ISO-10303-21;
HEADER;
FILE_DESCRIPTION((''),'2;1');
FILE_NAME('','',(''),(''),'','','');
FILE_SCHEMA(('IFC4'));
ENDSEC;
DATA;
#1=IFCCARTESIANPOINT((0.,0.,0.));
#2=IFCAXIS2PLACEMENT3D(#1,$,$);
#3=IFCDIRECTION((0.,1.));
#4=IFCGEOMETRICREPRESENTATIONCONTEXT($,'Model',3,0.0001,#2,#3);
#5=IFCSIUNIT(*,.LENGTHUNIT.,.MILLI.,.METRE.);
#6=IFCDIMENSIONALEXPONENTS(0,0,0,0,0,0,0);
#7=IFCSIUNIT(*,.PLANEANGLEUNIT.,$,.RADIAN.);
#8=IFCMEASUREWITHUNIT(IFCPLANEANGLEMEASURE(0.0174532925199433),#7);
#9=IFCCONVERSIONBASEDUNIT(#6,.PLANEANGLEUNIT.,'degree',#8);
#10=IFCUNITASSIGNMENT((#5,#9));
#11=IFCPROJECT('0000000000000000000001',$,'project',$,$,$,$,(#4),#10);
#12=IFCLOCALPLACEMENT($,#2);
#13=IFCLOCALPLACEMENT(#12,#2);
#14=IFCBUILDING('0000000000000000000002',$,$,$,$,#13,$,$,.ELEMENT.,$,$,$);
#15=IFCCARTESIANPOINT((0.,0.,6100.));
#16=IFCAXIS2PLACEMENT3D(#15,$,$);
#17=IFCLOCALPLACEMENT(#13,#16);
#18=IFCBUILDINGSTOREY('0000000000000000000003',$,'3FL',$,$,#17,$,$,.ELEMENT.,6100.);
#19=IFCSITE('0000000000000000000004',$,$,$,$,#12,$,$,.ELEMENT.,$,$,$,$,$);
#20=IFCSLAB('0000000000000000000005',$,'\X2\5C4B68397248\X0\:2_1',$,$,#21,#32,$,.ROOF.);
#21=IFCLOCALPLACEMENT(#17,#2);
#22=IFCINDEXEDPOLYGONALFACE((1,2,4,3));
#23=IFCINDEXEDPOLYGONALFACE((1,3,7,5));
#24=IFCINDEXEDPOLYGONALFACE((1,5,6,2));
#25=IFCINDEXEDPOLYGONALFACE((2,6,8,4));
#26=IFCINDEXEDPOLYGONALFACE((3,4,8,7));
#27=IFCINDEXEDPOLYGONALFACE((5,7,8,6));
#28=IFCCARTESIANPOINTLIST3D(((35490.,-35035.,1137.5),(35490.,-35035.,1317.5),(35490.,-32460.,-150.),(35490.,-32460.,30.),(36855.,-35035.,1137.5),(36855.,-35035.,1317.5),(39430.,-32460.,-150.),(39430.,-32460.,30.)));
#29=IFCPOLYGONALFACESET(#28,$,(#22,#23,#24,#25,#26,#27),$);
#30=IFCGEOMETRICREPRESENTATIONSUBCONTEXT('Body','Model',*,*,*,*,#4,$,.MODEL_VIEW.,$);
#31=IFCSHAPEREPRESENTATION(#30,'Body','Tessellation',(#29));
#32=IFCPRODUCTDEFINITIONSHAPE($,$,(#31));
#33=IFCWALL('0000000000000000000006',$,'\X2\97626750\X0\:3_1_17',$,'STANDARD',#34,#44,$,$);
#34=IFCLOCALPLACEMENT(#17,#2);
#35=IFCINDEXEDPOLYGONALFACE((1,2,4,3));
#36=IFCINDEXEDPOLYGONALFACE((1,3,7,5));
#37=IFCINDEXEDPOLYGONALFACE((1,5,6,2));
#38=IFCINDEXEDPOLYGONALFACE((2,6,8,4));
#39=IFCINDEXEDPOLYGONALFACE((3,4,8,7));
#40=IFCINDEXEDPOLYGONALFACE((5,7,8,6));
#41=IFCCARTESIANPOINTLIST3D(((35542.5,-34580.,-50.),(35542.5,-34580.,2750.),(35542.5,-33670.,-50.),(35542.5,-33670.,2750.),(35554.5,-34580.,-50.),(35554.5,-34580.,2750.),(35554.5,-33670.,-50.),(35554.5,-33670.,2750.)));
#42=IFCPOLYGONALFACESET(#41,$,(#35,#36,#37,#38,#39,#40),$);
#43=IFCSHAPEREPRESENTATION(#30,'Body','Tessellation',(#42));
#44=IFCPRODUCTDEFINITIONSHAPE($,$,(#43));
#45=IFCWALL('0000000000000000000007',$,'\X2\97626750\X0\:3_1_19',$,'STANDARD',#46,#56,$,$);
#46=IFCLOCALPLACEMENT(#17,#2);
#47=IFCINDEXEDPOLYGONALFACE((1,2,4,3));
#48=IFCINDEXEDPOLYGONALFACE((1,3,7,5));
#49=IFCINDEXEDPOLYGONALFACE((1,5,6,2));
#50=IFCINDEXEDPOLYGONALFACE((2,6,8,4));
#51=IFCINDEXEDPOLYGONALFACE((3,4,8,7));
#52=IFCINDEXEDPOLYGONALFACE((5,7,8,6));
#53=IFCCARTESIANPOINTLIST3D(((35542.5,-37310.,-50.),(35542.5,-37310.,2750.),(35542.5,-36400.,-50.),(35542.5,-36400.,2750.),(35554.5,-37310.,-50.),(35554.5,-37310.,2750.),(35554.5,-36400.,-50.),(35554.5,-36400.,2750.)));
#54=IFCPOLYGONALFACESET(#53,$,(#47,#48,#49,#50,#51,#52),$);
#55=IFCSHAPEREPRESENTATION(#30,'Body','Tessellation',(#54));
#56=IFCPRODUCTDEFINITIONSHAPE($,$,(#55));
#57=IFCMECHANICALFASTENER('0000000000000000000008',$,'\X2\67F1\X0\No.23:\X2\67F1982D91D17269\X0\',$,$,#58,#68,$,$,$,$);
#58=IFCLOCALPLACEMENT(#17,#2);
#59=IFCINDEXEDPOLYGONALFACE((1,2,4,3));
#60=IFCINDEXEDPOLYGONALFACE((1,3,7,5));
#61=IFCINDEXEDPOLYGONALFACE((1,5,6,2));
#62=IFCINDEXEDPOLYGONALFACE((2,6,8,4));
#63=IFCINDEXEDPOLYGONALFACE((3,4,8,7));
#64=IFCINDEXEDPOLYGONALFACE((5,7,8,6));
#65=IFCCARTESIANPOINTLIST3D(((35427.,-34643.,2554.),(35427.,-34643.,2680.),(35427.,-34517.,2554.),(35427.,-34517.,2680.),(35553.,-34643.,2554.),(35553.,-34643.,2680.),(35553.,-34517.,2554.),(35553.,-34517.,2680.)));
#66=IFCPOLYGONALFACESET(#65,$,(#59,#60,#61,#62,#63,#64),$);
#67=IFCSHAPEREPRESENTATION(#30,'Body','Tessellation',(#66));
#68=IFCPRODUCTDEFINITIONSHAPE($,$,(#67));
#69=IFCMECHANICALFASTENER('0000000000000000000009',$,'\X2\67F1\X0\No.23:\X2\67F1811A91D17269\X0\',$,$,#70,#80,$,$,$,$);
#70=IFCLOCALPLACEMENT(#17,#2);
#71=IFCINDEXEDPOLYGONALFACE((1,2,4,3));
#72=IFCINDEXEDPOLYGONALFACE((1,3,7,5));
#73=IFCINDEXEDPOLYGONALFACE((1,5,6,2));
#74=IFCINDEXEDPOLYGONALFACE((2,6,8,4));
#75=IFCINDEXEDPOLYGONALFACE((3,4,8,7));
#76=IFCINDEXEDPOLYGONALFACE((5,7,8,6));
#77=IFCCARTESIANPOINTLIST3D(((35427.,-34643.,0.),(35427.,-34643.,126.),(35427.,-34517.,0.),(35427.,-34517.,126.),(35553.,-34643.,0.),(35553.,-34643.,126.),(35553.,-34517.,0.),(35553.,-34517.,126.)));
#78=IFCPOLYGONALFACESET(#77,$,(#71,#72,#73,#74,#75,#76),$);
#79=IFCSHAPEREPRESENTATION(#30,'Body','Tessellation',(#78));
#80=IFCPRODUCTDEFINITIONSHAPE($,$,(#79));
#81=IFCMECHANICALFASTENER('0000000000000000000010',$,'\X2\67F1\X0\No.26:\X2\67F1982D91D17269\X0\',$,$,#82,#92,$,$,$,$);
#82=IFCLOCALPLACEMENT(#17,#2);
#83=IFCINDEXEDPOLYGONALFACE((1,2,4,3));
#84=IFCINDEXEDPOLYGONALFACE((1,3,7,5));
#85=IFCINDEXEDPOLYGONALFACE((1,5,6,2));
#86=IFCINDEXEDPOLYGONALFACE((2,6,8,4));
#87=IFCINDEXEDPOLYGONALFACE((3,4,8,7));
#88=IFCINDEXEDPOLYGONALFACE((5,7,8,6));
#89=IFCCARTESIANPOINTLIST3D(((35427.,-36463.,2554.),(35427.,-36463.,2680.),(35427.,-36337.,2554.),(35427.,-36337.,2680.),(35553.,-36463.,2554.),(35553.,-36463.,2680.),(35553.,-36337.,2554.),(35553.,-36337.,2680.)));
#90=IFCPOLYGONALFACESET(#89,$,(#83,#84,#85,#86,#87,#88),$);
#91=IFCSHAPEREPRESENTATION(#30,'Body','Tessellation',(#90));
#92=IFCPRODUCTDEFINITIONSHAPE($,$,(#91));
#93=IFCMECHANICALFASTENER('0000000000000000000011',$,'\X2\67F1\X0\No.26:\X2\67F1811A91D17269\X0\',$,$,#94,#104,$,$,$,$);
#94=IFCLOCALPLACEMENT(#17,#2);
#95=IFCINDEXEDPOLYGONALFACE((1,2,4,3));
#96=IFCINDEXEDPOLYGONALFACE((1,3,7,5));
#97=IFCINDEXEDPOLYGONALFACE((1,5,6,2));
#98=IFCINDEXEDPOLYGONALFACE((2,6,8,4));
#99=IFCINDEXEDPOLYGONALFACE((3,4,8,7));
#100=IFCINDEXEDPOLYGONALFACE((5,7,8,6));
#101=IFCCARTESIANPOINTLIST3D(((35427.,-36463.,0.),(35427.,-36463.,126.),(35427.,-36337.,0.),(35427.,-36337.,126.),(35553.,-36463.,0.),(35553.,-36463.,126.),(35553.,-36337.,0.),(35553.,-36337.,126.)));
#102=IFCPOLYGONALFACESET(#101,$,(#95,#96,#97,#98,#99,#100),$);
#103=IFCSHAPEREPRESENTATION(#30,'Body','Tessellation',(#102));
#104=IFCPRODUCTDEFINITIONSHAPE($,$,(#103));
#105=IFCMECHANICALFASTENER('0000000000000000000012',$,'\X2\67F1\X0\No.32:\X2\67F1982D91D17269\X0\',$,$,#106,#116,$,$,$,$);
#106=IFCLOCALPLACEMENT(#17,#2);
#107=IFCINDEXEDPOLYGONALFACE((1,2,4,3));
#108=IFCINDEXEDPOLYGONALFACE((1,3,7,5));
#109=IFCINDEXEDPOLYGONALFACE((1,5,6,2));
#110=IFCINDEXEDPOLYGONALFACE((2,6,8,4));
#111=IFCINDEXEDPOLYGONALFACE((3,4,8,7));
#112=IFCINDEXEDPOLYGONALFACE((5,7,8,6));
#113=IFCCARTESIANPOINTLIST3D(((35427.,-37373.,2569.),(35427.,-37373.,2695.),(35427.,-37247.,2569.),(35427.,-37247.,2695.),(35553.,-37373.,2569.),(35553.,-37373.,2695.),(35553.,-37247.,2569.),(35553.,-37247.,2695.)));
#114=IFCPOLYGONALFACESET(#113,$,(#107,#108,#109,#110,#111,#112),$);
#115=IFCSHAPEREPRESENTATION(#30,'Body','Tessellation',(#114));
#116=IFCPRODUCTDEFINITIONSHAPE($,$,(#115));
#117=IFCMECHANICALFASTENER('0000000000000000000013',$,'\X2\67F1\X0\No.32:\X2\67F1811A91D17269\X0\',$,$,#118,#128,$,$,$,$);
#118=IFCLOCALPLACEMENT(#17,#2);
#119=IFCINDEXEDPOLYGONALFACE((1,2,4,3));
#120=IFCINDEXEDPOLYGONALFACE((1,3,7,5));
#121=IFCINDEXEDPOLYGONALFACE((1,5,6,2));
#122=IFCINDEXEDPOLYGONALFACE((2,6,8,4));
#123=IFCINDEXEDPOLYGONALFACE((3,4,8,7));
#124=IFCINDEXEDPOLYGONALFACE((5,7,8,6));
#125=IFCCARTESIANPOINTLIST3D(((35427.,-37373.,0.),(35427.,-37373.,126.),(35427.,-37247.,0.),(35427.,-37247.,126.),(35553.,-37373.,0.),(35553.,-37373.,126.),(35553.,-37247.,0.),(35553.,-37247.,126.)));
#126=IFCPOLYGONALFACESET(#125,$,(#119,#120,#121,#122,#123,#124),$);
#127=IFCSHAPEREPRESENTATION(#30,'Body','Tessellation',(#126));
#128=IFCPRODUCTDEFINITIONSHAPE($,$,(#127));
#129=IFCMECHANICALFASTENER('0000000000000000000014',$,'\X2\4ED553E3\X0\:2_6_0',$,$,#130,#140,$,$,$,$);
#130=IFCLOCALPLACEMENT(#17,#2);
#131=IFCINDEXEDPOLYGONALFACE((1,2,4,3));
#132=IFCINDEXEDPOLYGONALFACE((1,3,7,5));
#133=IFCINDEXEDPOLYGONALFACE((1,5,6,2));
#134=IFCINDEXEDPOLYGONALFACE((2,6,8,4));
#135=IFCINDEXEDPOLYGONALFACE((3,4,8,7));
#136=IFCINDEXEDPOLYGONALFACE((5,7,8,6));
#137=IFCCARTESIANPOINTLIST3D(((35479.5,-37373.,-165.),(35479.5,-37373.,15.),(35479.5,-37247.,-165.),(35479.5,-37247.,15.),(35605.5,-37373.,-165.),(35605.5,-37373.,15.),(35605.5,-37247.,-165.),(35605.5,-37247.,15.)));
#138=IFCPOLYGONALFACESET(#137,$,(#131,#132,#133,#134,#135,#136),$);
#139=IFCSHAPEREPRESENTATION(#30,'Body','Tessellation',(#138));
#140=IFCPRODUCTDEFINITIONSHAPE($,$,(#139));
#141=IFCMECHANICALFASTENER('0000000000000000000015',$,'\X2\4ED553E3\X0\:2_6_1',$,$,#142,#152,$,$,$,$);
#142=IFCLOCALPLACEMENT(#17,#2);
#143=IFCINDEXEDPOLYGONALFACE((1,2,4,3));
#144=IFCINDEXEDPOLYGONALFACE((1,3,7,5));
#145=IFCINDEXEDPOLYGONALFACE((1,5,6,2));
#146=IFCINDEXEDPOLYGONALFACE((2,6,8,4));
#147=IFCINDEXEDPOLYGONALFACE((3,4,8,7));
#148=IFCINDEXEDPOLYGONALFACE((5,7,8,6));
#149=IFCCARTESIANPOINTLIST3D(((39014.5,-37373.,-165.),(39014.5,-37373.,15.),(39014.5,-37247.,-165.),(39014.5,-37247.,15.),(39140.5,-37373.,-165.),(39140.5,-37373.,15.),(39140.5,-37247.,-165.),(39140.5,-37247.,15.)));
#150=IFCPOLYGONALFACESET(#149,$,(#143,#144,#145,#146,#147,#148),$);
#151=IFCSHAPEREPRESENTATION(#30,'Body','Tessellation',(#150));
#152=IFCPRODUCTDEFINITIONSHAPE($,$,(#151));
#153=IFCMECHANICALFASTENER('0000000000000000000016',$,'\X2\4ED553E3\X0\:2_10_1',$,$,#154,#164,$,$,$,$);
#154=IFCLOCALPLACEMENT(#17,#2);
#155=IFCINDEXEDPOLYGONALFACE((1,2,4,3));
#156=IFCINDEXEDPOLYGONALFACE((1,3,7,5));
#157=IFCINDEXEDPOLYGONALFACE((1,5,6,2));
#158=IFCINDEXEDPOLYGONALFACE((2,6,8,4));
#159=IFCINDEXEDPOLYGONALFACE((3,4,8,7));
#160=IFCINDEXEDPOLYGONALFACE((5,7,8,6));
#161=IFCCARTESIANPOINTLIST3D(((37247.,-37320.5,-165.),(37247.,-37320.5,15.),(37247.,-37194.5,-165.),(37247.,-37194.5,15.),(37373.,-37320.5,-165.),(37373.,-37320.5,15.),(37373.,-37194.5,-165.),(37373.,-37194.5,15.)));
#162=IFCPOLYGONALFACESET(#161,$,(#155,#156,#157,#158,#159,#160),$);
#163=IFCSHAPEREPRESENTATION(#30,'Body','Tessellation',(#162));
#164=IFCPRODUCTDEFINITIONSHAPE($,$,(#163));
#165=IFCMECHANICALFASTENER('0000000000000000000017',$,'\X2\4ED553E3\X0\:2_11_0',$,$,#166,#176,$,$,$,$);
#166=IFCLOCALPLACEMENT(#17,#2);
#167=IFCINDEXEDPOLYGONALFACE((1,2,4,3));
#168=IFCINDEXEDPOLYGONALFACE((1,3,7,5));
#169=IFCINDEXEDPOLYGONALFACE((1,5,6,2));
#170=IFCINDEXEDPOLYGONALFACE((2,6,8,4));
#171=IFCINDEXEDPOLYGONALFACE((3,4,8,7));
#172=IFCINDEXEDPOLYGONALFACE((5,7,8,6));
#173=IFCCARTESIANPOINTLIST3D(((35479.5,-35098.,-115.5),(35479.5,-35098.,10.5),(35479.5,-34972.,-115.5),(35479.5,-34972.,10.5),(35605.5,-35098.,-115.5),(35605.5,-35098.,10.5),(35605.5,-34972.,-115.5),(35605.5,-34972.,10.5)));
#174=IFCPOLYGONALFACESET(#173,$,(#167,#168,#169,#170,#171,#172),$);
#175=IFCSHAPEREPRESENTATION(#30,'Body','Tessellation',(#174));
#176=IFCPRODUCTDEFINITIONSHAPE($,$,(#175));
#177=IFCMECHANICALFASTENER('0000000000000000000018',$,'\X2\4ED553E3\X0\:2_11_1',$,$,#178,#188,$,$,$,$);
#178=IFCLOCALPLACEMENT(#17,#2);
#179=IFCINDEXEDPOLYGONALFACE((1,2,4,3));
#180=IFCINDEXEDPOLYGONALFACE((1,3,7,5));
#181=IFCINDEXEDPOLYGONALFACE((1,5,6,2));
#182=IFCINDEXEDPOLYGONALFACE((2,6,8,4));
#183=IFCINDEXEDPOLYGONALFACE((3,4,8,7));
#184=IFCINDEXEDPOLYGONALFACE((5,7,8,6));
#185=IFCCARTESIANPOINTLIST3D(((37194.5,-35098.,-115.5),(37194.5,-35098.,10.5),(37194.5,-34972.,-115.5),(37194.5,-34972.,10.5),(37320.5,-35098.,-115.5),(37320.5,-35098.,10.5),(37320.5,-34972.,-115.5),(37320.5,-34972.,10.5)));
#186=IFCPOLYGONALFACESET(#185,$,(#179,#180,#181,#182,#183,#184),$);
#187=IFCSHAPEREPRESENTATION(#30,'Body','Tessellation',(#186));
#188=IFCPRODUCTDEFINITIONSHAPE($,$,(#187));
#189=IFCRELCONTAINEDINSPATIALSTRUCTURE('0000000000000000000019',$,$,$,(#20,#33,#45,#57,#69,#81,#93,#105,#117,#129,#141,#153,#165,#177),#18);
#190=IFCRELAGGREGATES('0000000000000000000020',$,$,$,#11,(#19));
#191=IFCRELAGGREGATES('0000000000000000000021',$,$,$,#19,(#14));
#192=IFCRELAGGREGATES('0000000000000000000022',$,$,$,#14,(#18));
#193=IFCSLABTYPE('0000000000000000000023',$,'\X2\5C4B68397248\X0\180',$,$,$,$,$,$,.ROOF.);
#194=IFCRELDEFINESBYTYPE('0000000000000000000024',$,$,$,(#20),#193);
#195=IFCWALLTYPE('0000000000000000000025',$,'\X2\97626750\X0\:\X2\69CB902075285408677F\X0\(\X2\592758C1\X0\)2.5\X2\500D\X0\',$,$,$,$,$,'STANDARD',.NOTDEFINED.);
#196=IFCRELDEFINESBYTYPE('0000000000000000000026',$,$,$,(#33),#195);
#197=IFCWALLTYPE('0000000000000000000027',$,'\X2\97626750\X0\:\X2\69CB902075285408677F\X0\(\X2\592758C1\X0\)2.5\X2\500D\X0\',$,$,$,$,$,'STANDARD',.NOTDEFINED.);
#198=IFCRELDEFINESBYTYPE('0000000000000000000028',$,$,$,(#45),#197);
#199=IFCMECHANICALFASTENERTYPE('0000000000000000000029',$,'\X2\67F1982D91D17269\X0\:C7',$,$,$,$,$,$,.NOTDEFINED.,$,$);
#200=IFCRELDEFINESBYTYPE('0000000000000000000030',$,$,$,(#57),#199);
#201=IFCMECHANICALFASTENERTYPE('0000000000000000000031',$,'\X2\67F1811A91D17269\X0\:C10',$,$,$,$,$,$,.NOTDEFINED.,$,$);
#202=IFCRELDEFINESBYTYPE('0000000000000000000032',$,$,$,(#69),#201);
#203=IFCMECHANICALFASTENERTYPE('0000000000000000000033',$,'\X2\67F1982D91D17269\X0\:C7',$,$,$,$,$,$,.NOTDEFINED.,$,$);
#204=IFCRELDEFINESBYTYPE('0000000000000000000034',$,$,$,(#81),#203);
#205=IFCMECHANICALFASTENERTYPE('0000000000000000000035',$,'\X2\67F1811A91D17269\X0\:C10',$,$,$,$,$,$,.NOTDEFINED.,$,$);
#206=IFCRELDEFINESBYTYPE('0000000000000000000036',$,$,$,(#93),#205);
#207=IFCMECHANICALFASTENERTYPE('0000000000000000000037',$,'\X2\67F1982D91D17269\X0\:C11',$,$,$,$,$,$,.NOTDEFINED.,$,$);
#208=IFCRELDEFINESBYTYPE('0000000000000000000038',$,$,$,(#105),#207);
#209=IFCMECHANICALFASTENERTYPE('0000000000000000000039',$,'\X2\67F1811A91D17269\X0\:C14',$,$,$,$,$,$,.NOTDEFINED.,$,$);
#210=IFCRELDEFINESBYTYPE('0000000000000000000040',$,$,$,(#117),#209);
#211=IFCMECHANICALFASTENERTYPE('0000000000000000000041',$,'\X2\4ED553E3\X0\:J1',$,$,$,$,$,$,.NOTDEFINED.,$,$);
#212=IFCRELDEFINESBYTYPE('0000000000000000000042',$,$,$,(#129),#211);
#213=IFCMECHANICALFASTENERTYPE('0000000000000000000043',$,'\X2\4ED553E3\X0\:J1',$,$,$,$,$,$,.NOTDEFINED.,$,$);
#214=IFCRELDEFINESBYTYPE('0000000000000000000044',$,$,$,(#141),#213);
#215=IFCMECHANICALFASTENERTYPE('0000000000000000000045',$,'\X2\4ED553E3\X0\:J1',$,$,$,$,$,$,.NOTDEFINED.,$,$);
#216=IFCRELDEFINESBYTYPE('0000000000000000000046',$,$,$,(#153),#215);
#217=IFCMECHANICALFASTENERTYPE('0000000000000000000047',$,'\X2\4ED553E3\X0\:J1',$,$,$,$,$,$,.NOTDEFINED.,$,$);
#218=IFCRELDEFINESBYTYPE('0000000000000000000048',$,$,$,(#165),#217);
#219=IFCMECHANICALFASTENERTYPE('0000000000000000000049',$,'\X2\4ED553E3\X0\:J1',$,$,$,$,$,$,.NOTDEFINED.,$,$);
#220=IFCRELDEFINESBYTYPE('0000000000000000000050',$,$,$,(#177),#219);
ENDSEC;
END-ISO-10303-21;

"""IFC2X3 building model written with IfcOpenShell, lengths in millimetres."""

from ifc_helpers import new_model, entity, si_unit, converted_unit, direction, frame, origin, origin_with_axes, origin_2d, place, context, subcontext, project, spatial, polyline, rectangle, outline, extrude, type_object, element, save


model = new_model("IFC2X3")

# Units and contexts
model_context = context("Model", 3, precision=0.0001, world=origin(), true_north=direction((0.0, 1.0)))
body_context = subcontext(model_context, "Body", "Model", "MODEL_VIEW")
ifc_project = project(units=[si_unit("LENGTHUNIT", "METRE", prefix="MILLI"), converted_unit("PLANEANGLEUNIT", "degree", entity("IfcPlaneAngleMeasure", 0.0174532925199433), si_unit("PLANEANGLEUNIT", "RADIAN"), dimensions=[0, 0, 0, 0, 0, 0, 0])], contexts=[model_context])

# Site, building, storey
site_placement = place(None, origin())
site = spatial("IfcSite", under=ifc_project, at=site_placement, CompositionType="ELEMENT")
building_placement = place(site_placement, origin())
building = spatial("IfcBuilding", under=site, at=building_placement, CompositionType="ELEMENT")
storey_placement = place(building_placement, frame((0.0, 0.0, 6100.0)))
storey = spatial("IfcBuildingStorey", under=building, at=storey_placement, Name="3FL", CompositionType="ELEMENT", Elevation=6100.0)

# Slab
slab_type = type_object("IfcSlabType", Name="屋根版180", PredefinedType="ROOF")
slab_placement = place(storey_placement, frame((35490.0, -35035.0, 1137.5), z_axis=(0.0, 0.447214, 0.894427), x_axis=(1.0, 0.0, 0.0)))
element("IfcSlab", 1, at=slab_placement, inside=storey, type_object=slab_type, Name="屋根版:2_1", PredefinedType="ROOF", context=body_context, shape_type="SweptSolid", body=[
    extrude(outline(polyline([(0.0, 0.0, 0.0), (1365.0, 0.0, 0.0), (3940.0, 2878.9, 0.0), (0.0, 2878.9, 0.0), (0.0, 0.0, 0.0)])), origin_with_axes(), (0.0, -0.447214, 0.894427), 180.0),
])

# Walls
wall_type_1 = type_object("IfcWallType", Name="面材:構造用合板(大壁)2.5倍", ElementType="STANDARD", PredefinedType="NOTDEFINED")
wall_1_placement = place(storey_placement, frame((35554.5, -34125.0, -50.0), z_axis=(-1.0, 0.0, 0.0), x_axis=(0.0, -1.0, 0.0)))
element("IfcWall", 2, at=wall_1_placement, inside=storey, type_object=wall_type_1, Name="面材:3_1_17", ObjectType="STANDARD", context=body_context, shape_type="SweptSolid", body=[
    extrude(outline(polyline([(455.0, 0.0, 0.0), (-455.0, 0.0, 0.0), (-455.0, 2800.0, 0.0), (455.0, 2800.0, 0.0), (455.0, 0.0, 0.0)])), origin_with_axes(), (0.0, 0.0, 1.0), 12.0),
])
wall_type_2 = type_object("IfcWallType", Name="面材:構造用合板(大壁)2.5倍", ElementType="STANDARD", PredefinedType="NOTDEFINED")
wall_2_placement = place(storey_placement, frame((35554.5, -36855.0, -50.0), z_axis=(-1.0, 0.0, 0.0), x_axis=(0.0, -1.0, 0.0)))
element("IfcWall", 3, at=wall_2_placement, inside=storey, type_object=wall_type_2, Name="面材:3_1_19", ObjectType="STANDARD", context=body_context, shape_type="SweptSolid", body=[
    extrude(outline(polyline([(455.0, 0.0, 0.0), (-455.0, 0.0, 0.0), (-455.0, 2800.0, 0.0), (455.0, 2800.0, 0.0), (455.0, 0.0, 0.0)])), origin_with_axes(), (0.0, 0.0, 1.0), 12.0),
])

# Mechanical fasteners
mechanical_fastener_type_1 = type_object("IfcMechanicalFastenerType", Name="柱頭金物:C7")
mechanical_fastener_1_placement = place(storey_placement, frame((35490.0, -34580.0, 2554.0)))
element("IfcMechanicalFastener", 4, at=mechanical_fastener_1_placement, inside=storey, type_object=mechanical_fastener_type_1, Name="柱No.23:柱頭金物", context=body_context, shape_type="SweptSolid", body=[
    extrude(rectangle(XDim=126.0, YDim=126.0, at=origin_2d()), origin_with_axes(), (0.0, 0.0, 1.0), 126.0),
])
mechanical_fastener_type_2 = type_object("IfcMechanicalFastenerType", Name="柱脚金物:C10")
mechanical_fastener_2_placement = place(storey_placement, frame((35490.0, -34580.0, 0.0)))
element("IfcMechanicalFastener", 5, at=mechanical_fastener_2_placement, inside=storey, type_object=mechanical_fastener_type_2, Name="柱No.23:柱脚金物", context=body_context, shape_type="SweptSolid", body=[
    extrude(rectangle(XDim=126.0, YDim=126.0, at=origin_2d()), origin_with_axes(), (0.0, 0.0, 1.0), 126.0),
])
mechanical_fastener_type_3 = type_object("IfcMechanicalFastenerType", Name="柱頭金物:C7")
mechanical_fastener_3_placement = place(storey_placement, frame((35490.0, -36400.0, 2554.0)))
element("IfcMechanicalFastener", 6, at=mechanical_fastener_3_placement, inside=storey, type_object=mechanical_fastener_type_3, Name="柱No.26:柱頭金物", context=body_context, shape_type="SweptSolid", body=[
    extrude(rectangle(XDim=126.0, YDim=126.0, at=origin_2d()), origin_with_axes(), (0.0, 0.0, 1.0), 126.0),
])
mechanical_fastener_type_4 = type_object("IfcMechanicalFastenerType", Name="柱脚金物:C10")
mechanical_fastener_4_placement = place(storey_placement, frame((35490.0, -36400.0, 0.0)))
element("IfcMechanicalFastener", 7, at=mechanical_fastener_4_placement, inside=storey, type_object=mechanical_fastener_type_4, Name="柱No.26:柱脚金物", context=body_context, shape_type="SweptSolid", body=[
    extrude(rectangle(XDim=126.0, YDim=126.0, at=origin_2d()), origin_with_axes(), (0.0, 0.0, 1.0), 126.0),
])
mechanical_fastener_type_5 = type_object("IfcMechanicalFastenerType", Name="柱頭金物:C11")
mechanical_fastener_5_placement = place(storey_placement, frame((35490.0, -37310.0, 2569.0)))
element("IfcMechanicalFastener", 8, at=mechanical_fastener_5_placement, inside=storey, type_object=mechanical_fastener_type_5, Name="柱No.32:柱頭金物", context=body_context, shape_type="SweptSolid", body=[
    extrude(rectangle(XDim=126.0, YDim=126.0, at=origin_2d()), origin_with_axes(), (0.0, 0.0, 1.0), 126.0),
])
mechanical_fastener_type_6 = type_object("IfcMechanicalFastenerType", Name="柱脚金物:C14")
mechanical_fastener_6_placement = place(storey_placement, frame((35490.0, -37310.0, 0.0)))
element("IfcMechanicalFastener", 9, at=mechanical_fastener_6_placement, inside=storey, type_object=mechanical_fastener_type_6, Name="柱No.32:柱脚金物", context=body_context, shape_type="SweptSolid", body=[
    extrude(rectangle(XDim=126.0, YDim=126.0, at=origin_2d()), origin_with_axes(), (0.0, 0.0, 1.0), 126.0),
])
mechanical_fastener_type_7 = type_object("IfcMechanicalFastenerType", Name="仕口:J1")
mechanical_fastener_7_placement = place(storey_placement, frame((35542.5, -37310.0, -165.0)))
element("IfcMechanicalFastener", 10, at=mechanical_fastener_7_placement, inside=storey, type_object=mechanical_fastener_type_7, Name="仕口:2_6_0", context=body_context, shape_type="SweptSolid", body=[
    extrude(rectangle(XDim=126.0, YDim=126.0, at=origin_2d()), origin_with_axes(), (0.0, 0.0, 1.0), 180.0),
])
mechanical_fastener_type_8 = type_object("IfcMechanicalFastenerType", Name="仕口:J1")
mechanical_fastener_8_placement = place(storey_placement, frame((39077.5, -37310.0, -165.0)))
element("IfcMechanicalFastener", 11, at=mechanical_fastener_8_placement, inside=storey, type_object=mechanical_fastener_type_8, Name="仕口:2_6_1", context=body_context, shape_type="SweptSolid", body=[
    extrude(rectangle(XDim=126.0, YDim=126.0, at=origin_2d()), origin_with_axes(), (0.0, 0.0, 1.0), 180.0),
])
mechanical_fastener_type_9 = type_object("IfcMechanicalFastenerType", Name="仕口:J1")
mechanical_fastener_9_placement = place(storey_placement, frame((37310.0, -37257.5, -165.0)))
element("IfcMechanicalFastener", 12, at=mechanical_fastener_9_placement, inside=storey, type_object=mechanical_fastener_type_9, Name="仕口:2_10_1", context=body_context, shape_type="SweptSolid", body=[
    extrude(rectangle(XDim=126.0, YDim=126.0, at=origin_2d()), origin_with_axes(), (0.0, 0.0, 1.0), 180.0),
])
mechanical_fastener_type_10 = type_object("IfcMechanicalFastenerType", Name="仕口:J1")
mechanical_fastener_10_placement = place(storey_placement, frame((35542.5, -35035.0, -115.5)))
element("IfcMechanicalFastener", 13, at=mechanical_fastener_10_placement, inside=storey, type_object=mechanical_fastener_type_10, Name="仕口:2_11_0", context=body_context, shape_type="SweptSolid", body=[
    extrude(rectangle(XDim=126.0, YDim=126.0, at=origin_2d()), origin_with_axes(), (0.0, 0.0, 1.0), 126.0),
])
mechanical_fastener_type_11 = type_object("IfcMechanicalFastenerType", Name="仕口:J1")
mechanical_fastener_11_placement = place(storey_placement, frame((37257.5, -35035.0, -115.5)))
element("IfcMechanicalFastener", 14, at=mechanical_fastener_11_placement, inside=storey, type_object=mechanical_fastener_type_11, Name="仕口:2_11_1", context=body_context, shape_type="SweptSolid", body=[
    extrude(rectangle(XDim=126.0, YDim=126.0, at=origin_2d()), origin_with_axes(), (0.0, 0.0, 1.0), 126.0),
])

save(model, "model.ifc")
